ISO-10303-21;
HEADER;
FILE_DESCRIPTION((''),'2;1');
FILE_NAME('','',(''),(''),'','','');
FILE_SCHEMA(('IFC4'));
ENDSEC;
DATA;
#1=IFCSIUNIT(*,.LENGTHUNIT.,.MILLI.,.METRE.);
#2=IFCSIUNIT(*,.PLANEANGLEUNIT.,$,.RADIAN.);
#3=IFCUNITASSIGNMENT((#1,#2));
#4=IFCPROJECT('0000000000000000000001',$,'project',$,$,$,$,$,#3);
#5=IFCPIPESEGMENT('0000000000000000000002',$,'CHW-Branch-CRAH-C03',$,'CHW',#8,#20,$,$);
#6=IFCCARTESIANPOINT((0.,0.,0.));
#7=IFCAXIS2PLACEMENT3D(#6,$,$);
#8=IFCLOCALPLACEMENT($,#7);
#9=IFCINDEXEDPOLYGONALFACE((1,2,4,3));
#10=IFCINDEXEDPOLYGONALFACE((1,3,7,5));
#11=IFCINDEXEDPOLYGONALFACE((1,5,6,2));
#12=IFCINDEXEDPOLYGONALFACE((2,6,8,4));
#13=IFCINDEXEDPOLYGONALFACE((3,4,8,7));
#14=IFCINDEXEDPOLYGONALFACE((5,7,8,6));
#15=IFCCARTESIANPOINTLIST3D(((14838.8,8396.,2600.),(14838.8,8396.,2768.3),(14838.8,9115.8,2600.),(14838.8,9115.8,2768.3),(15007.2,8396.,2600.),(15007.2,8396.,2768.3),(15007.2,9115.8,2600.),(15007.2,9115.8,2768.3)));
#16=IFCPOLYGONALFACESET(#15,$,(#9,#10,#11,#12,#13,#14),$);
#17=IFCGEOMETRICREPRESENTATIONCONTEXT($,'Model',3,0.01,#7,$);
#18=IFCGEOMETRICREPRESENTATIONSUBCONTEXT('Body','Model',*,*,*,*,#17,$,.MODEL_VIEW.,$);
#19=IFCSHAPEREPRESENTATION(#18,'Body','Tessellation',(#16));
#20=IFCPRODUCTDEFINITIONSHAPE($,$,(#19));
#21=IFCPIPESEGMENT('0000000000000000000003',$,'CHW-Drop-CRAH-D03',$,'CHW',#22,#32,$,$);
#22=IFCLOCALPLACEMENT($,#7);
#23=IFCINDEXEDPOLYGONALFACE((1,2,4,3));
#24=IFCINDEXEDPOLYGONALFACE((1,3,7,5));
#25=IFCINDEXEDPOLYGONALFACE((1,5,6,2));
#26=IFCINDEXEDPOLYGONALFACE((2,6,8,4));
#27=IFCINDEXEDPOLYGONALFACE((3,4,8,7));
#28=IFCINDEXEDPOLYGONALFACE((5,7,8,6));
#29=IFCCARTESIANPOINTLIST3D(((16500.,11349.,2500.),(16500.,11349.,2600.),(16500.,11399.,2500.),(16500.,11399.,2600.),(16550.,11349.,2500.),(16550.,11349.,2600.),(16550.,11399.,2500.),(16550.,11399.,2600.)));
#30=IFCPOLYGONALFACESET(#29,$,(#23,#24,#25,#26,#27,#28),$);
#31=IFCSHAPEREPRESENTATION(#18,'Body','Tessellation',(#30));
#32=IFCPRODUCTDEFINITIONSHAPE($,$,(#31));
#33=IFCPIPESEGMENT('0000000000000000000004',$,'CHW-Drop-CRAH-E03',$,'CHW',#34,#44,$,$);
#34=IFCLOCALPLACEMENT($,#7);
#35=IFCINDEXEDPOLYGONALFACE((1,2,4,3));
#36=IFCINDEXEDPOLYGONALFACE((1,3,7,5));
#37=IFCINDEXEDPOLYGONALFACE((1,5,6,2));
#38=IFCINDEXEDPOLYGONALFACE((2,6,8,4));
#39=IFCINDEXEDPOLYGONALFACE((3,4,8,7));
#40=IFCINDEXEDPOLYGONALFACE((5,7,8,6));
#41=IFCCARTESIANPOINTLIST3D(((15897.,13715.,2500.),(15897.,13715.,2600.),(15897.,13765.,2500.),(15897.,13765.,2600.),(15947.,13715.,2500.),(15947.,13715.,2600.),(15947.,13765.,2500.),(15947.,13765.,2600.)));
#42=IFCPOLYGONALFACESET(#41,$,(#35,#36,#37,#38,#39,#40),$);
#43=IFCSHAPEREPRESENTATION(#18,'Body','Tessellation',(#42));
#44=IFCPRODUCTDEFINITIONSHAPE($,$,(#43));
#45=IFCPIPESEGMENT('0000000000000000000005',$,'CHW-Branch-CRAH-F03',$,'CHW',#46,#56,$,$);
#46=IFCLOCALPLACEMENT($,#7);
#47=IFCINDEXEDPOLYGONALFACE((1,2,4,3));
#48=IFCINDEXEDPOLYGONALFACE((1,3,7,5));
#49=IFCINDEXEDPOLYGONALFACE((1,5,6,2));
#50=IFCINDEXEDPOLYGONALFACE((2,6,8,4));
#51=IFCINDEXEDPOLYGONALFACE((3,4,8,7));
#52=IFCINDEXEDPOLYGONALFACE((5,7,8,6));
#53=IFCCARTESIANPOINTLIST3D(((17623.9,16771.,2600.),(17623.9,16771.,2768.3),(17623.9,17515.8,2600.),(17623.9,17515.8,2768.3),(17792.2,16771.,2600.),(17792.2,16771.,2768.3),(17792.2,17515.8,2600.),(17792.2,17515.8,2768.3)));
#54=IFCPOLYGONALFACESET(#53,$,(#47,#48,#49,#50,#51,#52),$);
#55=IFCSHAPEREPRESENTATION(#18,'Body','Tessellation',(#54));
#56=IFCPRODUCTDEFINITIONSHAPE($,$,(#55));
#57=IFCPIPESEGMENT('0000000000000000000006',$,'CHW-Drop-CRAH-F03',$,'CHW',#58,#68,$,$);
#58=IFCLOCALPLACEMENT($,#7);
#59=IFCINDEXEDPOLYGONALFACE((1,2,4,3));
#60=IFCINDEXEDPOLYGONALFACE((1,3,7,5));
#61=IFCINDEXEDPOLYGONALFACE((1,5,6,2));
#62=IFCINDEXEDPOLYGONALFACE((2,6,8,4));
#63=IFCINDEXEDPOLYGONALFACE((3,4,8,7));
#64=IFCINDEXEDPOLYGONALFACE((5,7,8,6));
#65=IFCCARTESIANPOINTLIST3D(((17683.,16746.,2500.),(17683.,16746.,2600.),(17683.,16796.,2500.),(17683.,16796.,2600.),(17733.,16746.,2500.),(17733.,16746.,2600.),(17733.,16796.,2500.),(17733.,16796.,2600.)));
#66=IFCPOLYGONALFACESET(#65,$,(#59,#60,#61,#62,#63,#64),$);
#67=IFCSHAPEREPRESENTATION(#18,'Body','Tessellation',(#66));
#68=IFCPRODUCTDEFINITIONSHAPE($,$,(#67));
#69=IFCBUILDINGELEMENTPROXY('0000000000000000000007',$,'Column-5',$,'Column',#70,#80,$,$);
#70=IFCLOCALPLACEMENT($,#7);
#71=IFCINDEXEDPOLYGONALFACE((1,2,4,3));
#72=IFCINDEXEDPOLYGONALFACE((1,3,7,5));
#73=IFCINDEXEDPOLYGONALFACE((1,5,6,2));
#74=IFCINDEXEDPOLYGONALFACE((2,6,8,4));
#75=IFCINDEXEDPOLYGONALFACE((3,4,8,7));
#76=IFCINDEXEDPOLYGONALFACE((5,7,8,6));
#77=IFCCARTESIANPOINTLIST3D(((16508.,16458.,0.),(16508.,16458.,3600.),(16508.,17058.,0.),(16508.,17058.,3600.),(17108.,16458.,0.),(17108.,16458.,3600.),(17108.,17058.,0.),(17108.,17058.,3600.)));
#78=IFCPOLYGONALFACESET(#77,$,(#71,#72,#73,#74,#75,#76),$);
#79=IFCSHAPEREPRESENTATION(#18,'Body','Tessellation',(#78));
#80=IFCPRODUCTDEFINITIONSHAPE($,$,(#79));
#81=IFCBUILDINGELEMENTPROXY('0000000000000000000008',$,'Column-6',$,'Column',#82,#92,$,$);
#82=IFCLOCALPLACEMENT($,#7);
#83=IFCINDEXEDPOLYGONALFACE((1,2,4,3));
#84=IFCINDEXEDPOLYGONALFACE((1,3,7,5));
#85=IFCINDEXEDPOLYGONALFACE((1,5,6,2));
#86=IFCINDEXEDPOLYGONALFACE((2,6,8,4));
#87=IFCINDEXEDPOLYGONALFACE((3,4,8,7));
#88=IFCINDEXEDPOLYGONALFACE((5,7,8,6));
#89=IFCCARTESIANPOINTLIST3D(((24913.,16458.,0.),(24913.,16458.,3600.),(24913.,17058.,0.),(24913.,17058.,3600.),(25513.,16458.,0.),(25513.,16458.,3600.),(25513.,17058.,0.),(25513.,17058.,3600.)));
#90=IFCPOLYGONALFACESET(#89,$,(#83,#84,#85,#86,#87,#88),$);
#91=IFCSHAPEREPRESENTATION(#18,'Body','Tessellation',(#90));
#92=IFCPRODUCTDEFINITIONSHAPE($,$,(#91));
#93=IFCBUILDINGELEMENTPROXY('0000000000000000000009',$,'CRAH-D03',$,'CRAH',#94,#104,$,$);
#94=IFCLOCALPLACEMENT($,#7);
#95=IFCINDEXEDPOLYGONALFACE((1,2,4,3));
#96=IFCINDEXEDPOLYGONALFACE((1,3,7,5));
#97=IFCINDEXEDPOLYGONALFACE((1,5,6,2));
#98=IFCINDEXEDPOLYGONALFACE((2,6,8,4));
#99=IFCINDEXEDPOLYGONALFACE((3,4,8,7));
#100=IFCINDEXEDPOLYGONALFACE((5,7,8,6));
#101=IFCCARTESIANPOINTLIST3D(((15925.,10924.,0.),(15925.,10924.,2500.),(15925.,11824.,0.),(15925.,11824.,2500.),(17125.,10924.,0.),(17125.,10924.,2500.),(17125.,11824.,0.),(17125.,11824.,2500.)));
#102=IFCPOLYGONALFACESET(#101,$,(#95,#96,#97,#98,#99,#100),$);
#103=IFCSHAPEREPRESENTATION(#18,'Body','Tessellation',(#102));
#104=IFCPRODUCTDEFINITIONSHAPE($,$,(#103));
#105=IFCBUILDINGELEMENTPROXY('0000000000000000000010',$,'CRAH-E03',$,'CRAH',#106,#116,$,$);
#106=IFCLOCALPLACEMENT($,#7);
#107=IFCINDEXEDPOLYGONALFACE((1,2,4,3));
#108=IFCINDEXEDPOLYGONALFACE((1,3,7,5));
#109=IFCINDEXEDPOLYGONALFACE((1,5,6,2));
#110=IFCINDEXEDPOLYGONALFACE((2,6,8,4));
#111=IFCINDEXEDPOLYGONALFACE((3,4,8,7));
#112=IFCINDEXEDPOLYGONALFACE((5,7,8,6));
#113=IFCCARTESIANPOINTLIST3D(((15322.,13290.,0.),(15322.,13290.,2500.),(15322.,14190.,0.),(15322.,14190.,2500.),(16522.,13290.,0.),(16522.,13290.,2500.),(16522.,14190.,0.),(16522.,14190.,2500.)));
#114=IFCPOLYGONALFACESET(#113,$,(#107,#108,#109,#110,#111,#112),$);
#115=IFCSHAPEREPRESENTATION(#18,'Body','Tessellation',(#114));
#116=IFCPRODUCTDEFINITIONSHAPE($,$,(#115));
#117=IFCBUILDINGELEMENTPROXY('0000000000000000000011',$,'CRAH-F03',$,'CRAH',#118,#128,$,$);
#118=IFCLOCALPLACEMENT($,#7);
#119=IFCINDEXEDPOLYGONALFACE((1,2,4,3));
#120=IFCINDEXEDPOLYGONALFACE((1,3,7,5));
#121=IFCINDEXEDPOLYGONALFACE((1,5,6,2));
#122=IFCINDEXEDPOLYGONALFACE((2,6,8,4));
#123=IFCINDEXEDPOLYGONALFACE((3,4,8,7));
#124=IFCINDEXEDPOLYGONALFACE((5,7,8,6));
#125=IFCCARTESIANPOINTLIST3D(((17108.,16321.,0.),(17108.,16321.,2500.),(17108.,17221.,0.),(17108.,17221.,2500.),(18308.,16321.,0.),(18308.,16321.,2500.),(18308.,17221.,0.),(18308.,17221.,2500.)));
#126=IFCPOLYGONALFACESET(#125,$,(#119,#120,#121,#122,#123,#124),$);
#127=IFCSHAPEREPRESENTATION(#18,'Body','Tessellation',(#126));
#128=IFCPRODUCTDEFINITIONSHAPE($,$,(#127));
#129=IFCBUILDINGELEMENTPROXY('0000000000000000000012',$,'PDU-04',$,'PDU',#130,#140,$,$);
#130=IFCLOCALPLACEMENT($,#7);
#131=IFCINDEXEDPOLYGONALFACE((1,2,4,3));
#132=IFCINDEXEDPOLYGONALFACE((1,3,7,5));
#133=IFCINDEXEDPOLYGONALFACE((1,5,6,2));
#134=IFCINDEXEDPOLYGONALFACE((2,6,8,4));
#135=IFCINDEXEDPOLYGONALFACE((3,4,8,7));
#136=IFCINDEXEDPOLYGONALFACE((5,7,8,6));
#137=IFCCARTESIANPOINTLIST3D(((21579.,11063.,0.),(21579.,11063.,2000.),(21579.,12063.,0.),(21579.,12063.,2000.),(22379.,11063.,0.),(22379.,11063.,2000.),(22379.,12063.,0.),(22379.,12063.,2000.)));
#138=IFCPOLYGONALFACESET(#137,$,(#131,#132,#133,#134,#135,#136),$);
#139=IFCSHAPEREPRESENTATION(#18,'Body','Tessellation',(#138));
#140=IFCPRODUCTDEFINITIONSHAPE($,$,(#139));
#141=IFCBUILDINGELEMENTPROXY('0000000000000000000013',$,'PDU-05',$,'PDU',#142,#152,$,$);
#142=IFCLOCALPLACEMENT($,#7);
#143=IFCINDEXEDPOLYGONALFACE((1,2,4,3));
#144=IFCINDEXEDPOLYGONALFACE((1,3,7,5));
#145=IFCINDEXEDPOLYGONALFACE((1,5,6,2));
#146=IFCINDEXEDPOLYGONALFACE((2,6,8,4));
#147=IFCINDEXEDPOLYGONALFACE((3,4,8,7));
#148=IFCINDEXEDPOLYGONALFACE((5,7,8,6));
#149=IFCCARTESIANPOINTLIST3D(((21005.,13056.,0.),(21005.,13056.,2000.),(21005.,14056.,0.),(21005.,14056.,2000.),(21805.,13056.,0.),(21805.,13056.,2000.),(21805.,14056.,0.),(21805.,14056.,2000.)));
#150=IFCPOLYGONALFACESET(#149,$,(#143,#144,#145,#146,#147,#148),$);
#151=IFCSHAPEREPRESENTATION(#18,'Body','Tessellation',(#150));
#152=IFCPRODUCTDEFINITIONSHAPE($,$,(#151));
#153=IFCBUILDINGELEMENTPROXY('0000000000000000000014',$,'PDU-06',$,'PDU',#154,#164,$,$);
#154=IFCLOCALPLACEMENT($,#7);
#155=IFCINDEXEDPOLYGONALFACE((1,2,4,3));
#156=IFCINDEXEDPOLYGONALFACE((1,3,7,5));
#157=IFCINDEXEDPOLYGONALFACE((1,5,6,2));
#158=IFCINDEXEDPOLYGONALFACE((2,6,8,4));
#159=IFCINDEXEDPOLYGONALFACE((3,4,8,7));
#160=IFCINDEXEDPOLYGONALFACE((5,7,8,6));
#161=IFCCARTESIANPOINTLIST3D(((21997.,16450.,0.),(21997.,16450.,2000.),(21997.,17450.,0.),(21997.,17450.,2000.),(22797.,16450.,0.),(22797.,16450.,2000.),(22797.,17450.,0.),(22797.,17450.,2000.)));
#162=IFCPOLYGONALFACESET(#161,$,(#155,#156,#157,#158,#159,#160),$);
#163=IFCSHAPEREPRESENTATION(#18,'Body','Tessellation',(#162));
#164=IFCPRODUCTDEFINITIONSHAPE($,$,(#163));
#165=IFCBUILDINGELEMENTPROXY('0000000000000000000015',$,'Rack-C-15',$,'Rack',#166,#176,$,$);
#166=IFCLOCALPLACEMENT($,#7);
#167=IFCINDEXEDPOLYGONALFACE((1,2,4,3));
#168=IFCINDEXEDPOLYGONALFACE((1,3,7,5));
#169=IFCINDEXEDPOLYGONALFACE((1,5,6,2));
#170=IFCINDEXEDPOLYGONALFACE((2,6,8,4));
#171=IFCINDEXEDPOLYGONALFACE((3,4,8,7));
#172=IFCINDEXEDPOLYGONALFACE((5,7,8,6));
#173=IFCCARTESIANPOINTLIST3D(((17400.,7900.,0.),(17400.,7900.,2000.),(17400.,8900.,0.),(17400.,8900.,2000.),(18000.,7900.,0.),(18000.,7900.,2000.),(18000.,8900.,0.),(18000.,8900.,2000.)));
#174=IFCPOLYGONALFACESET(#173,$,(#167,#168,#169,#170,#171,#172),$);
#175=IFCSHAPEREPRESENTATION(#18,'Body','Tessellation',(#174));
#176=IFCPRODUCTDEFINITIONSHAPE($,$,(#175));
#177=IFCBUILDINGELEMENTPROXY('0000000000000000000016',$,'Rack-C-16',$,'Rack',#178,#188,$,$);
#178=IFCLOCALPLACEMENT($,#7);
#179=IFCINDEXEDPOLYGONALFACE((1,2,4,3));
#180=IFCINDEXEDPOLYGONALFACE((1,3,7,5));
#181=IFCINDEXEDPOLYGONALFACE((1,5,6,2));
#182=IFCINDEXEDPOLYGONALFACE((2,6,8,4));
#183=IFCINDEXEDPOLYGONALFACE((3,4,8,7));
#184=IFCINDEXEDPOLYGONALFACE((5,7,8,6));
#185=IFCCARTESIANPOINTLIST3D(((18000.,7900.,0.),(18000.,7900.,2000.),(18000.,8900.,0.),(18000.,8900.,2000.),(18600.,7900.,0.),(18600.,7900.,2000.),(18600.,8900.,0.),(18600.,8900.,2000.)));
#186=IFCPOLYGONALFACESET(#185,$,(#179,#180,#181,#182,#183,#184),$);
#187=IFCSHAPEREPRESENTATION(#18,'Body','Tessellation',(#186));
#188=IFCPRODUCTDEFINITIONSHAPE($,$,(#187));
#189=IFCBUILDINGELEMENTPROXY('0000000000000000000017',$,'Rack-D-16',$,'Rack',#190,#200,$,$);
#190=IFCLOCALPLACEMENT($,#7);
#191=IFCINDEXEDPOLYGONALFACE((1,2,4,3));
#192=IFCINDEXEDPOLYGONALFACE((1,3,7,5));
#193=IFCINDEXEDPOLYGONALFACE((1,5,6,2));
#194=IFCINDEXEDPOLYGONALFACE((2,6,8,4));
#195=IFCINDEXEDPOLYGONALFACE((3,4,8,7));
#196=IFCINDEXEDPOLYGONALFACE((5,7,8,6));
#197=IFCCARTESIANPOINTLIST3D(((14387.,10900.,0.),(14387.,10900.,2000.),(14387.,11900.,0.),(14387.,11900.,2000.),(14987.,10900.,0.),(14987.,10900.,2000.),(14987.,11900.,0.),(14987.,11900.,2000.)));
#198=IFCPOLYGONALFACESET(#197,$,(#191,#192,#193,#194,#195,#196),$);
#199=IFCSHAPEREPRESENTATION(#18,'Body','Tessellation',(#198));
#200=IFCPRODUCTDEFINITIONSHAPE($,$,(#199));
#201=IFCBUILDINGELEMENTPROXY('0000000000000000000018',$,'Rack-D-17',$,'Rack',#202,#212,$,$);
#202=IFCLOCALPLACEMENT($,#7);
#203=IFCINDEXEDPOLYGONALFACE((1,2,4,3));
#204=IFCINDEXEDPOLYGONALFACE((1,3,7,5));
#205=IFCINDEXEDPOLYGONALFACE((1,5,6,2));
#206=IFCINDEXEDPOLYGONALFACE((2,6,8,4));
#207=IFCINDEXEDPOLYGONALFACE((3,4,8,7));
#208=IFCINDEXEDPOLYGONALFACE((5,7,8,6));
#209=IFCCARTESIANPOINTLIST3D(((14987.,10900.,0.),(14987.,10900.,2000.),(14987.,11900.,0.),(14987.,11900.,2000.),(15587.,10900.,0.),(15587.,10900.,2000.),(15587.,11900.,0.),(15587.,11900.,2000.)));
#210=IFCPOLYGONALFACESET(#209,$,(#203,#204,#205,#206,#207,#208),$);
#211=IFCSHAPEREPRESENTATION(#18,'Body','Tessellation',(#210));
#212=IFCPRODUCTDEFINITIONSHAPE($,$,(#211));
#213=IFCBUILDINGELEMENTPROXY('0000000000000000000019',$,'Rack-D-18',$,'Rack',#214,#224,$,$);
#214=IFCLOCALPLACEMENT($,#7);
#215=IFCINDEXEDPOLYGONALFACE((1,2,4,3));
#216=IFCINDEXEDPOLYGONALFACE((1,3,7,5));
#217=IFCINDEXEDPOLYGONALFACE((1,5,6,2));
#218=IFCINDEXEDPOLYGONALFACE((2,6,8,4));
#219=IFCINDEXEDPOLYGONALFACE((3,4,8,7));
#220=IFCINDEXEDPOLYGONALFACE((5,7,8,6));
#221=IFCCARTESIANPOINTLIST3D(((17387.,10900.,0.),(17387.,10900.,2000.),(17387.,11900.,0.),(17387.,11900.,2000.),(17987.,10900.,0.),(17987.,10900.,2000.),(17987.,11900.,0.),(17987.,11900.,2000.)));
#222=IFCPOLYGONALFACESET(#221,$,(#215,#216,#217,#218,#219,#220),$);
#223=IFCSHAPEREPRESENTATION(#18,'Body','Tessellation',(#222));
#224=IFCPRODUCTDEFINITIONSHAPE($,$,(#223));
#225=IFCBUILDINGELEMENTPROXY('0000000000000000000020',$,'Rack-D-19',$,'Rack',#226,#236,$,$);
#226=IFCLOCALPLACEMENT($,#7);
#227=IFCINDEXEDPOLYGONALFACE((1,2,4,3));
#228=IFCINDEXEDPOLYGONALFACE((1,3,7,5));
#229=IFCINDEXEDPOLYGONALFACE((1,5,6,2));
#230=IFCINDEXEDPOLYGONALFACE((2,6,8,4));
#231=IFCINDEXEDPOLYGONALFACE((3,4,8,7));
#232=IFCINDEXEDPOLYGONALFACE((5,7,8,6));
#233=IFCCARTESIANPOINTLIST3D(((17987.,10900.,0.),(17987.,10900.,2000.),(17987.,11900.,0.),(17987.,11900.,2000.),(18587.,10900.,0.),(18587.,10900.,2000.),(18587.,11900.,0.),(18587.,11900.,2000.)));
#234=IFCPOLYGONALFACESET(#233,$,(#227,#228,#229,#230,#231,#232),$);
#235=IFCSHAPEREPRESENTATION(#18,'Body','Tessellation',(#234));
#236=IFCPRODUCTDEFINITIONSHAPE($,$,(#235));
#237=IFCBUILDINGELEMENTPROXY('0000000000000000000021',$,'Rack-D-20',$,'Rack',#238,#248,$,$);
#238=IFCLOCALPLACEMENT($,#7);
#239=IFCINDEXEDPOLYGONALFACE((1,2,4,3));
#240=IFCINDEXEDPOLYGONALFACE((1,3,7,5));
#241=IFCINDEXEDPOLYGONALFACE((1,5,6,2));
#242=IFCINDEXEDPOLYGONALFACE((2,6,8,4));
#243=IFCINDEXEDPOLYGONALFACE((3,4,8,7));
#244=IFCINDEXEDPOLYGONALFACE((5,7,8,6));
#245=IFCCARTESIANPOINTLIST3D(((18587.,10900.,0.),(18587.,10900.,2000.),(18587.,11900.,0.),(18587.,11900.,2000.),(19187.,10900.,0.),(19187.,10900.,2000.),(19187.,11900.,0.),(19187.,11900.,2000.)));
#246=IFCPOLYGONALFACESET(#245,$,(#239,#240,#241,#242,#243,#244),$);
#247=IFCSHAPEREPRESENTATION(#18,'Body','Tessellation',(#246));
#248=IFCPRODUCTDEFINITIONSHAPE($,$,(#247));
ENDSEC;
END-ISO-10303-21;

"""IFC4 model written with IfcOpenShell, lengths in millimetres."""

from ifc_helpers import new_model, si_unit, frame, origin, place, context, subcontext, project, rectangle, extrude, element, save


model = new_model("IFC4")

# Units and contexts
model_context = context("Model", 3, precision=0.01, world=origin())
body_context = subcontext(model_context, "Body", "Model", "MODEL_VIEW")
ifc_project = project(units=[si_unit("LENGTHUNIT", "METRE", prefix="MILLI"), si_unit("PLANEANGLEUNIT", "RADIAN")])

# Pipe segments
placement = place(None, origin())
pipe_segment_1_placement = place(placement, frame((14923.0, 8755.9, 2600.0)))
element("IfcPipeSegment", 1, at=pipe_segment_1_placement, Name="CHW-Branch-CRAH-C03", ObjectType="CHW", context=body_context, shape_type="SweptSolid", body=[
    extrude(rectangle(XDim=168.3, YDim=719.9), origin(), (0.0, 0.0, 1.0), 168.3),
])
for number, where, name in (
    (2, (16525.0, 11374.0, 2500.0), "CHW-Drop-CRAH-D03"),
    (3, (15922.0, 13740.0, 2500.0), "CHW-Drop-CRAH-E03"),
):
    element("IfcPipeSegment", number, at=place(placement, frame(where)), Name=name, ObjectType="CHW", context=body_context, shape_type="SweptSolid", body=[
        extrude(rectangle(XDim=50.0, YDim=50.0), origin(), (0.0, 0.0, 1.0), 100.0),
    ])
pipe_segment_2_placement = place(placement, frame((17708.0, 17143.4, 2600.0)))
element("IfcPipeSegment", 4, at=pipe_segment_2_placement, Name="CHW-Branch-CRAH-F03", ObjectType="CHW", context=body_context, shape_type="SweptSolid", body=[
    extrude(rectangle(XDim=168.3, YDim=744.8), origin(), (0.0, 0.0, 1.0), 168.3),
])
pipe_segment_3_placement = place(placement, frame((17708.0, 16771.0, 2500.0)))
element("IfcPipeSegment", 5, at=pipe_segment_3_placement, Name="CHW-Drop-CRAH-F03", ObjectType="CHW", context=body_context, shape_type="SweptSolid", body=[
    extrude(rectangle(XDim=50.0, YDim=50.0), origin(), (0.0, 0.0, 1.0), 100.0),
])

# Building element proxies
for number, where, name in (
    (6, (16808.0, 16758.0, 0.0), "Column-5"),
    (7, (25213.0, 16758.0, 0.0), "Column-6"),
):
    element("IfcBuildingElementProxy", number, at=place(placement, frame(where)), Name=name, ObjectType="Column", context=body_context, shape_type="SweptSolid", body=[
        extrude(rectangle(XDim=600.0, YDim=600.0), origin(), (0.0, 0.0, 1.0), 3600.0),
    ])
for number, where, name in (
    (8, (16525.0, 11374.0, 0.0), "CRAH-D03"),
    (9, (15922.0, 13740.0, 0.0), "CRAH-E03"),
    (10, (17708.0, 16771.0, 0.0), "CRAH-F03"),
):
    element("IfcBuildingElementProxy", number, at=place(placement, frame(where)), Name=name, ObjectType="CRAH", context=body_context, shape_type="SweptSolid", body=[
        extrude(rectangle(XDim=1200.0, YDim=900.0), origin(), (0.0, 0.0, 1.0), 2500.0),
    ])
for number, where, name in (
    (11, (21979.0, 11563.0, 0.0), "PDU-04"),
    (12, (21405.0, 13556.0, 0.0), "PDU-05"),
    (13, (22397.0, 16950.0, 0.0), "PDU-06"),
):
    element("IfcBuildingElementProxy", number, at=place(placement, frame(where)), Name=name, ObjectType="PDU", context=body_context, shape_type="SweptSolid", body=[
        extrude(rectangle(XDim=800.0, YDim=1000.0), origin(), (0.0, 0.0, 1.0), 2000.0),
    ])
for number, where, name in (
    (14, (17700.0, 8400.0, 0.0), "Rack-C-15"),
    (15, (18300.0, 8400.0, 0.0), "Rack-C-16"),
    (16, (14687.0, 11400.0, 0.0), "Rack-D-16"),
    (17, (15287.0, 11400.0, 0.0), "Rack-D-17"),
    (18, (17687.0, 11400.0, 0.0), "Rack-D-18"),
    (19, (18287.0, 11400.0, 0.0), "Rack-D-19"),
    (20, (18887.0, 11400.0, 0.0), "Rack-D-20"),
):
    element("IfcBuildingElementProxy", number, at=place(placement, frame(where)), Name=name, ObjectType="Rack", context=body_context, shape_type="SweptSolid", body=[
        extrude(rectangle(XDim=600.0, YDim=1000.0), origin(), (0.0, 0.0, 1.0), 2000.0),
    ])

save(model, "model.ifc")
